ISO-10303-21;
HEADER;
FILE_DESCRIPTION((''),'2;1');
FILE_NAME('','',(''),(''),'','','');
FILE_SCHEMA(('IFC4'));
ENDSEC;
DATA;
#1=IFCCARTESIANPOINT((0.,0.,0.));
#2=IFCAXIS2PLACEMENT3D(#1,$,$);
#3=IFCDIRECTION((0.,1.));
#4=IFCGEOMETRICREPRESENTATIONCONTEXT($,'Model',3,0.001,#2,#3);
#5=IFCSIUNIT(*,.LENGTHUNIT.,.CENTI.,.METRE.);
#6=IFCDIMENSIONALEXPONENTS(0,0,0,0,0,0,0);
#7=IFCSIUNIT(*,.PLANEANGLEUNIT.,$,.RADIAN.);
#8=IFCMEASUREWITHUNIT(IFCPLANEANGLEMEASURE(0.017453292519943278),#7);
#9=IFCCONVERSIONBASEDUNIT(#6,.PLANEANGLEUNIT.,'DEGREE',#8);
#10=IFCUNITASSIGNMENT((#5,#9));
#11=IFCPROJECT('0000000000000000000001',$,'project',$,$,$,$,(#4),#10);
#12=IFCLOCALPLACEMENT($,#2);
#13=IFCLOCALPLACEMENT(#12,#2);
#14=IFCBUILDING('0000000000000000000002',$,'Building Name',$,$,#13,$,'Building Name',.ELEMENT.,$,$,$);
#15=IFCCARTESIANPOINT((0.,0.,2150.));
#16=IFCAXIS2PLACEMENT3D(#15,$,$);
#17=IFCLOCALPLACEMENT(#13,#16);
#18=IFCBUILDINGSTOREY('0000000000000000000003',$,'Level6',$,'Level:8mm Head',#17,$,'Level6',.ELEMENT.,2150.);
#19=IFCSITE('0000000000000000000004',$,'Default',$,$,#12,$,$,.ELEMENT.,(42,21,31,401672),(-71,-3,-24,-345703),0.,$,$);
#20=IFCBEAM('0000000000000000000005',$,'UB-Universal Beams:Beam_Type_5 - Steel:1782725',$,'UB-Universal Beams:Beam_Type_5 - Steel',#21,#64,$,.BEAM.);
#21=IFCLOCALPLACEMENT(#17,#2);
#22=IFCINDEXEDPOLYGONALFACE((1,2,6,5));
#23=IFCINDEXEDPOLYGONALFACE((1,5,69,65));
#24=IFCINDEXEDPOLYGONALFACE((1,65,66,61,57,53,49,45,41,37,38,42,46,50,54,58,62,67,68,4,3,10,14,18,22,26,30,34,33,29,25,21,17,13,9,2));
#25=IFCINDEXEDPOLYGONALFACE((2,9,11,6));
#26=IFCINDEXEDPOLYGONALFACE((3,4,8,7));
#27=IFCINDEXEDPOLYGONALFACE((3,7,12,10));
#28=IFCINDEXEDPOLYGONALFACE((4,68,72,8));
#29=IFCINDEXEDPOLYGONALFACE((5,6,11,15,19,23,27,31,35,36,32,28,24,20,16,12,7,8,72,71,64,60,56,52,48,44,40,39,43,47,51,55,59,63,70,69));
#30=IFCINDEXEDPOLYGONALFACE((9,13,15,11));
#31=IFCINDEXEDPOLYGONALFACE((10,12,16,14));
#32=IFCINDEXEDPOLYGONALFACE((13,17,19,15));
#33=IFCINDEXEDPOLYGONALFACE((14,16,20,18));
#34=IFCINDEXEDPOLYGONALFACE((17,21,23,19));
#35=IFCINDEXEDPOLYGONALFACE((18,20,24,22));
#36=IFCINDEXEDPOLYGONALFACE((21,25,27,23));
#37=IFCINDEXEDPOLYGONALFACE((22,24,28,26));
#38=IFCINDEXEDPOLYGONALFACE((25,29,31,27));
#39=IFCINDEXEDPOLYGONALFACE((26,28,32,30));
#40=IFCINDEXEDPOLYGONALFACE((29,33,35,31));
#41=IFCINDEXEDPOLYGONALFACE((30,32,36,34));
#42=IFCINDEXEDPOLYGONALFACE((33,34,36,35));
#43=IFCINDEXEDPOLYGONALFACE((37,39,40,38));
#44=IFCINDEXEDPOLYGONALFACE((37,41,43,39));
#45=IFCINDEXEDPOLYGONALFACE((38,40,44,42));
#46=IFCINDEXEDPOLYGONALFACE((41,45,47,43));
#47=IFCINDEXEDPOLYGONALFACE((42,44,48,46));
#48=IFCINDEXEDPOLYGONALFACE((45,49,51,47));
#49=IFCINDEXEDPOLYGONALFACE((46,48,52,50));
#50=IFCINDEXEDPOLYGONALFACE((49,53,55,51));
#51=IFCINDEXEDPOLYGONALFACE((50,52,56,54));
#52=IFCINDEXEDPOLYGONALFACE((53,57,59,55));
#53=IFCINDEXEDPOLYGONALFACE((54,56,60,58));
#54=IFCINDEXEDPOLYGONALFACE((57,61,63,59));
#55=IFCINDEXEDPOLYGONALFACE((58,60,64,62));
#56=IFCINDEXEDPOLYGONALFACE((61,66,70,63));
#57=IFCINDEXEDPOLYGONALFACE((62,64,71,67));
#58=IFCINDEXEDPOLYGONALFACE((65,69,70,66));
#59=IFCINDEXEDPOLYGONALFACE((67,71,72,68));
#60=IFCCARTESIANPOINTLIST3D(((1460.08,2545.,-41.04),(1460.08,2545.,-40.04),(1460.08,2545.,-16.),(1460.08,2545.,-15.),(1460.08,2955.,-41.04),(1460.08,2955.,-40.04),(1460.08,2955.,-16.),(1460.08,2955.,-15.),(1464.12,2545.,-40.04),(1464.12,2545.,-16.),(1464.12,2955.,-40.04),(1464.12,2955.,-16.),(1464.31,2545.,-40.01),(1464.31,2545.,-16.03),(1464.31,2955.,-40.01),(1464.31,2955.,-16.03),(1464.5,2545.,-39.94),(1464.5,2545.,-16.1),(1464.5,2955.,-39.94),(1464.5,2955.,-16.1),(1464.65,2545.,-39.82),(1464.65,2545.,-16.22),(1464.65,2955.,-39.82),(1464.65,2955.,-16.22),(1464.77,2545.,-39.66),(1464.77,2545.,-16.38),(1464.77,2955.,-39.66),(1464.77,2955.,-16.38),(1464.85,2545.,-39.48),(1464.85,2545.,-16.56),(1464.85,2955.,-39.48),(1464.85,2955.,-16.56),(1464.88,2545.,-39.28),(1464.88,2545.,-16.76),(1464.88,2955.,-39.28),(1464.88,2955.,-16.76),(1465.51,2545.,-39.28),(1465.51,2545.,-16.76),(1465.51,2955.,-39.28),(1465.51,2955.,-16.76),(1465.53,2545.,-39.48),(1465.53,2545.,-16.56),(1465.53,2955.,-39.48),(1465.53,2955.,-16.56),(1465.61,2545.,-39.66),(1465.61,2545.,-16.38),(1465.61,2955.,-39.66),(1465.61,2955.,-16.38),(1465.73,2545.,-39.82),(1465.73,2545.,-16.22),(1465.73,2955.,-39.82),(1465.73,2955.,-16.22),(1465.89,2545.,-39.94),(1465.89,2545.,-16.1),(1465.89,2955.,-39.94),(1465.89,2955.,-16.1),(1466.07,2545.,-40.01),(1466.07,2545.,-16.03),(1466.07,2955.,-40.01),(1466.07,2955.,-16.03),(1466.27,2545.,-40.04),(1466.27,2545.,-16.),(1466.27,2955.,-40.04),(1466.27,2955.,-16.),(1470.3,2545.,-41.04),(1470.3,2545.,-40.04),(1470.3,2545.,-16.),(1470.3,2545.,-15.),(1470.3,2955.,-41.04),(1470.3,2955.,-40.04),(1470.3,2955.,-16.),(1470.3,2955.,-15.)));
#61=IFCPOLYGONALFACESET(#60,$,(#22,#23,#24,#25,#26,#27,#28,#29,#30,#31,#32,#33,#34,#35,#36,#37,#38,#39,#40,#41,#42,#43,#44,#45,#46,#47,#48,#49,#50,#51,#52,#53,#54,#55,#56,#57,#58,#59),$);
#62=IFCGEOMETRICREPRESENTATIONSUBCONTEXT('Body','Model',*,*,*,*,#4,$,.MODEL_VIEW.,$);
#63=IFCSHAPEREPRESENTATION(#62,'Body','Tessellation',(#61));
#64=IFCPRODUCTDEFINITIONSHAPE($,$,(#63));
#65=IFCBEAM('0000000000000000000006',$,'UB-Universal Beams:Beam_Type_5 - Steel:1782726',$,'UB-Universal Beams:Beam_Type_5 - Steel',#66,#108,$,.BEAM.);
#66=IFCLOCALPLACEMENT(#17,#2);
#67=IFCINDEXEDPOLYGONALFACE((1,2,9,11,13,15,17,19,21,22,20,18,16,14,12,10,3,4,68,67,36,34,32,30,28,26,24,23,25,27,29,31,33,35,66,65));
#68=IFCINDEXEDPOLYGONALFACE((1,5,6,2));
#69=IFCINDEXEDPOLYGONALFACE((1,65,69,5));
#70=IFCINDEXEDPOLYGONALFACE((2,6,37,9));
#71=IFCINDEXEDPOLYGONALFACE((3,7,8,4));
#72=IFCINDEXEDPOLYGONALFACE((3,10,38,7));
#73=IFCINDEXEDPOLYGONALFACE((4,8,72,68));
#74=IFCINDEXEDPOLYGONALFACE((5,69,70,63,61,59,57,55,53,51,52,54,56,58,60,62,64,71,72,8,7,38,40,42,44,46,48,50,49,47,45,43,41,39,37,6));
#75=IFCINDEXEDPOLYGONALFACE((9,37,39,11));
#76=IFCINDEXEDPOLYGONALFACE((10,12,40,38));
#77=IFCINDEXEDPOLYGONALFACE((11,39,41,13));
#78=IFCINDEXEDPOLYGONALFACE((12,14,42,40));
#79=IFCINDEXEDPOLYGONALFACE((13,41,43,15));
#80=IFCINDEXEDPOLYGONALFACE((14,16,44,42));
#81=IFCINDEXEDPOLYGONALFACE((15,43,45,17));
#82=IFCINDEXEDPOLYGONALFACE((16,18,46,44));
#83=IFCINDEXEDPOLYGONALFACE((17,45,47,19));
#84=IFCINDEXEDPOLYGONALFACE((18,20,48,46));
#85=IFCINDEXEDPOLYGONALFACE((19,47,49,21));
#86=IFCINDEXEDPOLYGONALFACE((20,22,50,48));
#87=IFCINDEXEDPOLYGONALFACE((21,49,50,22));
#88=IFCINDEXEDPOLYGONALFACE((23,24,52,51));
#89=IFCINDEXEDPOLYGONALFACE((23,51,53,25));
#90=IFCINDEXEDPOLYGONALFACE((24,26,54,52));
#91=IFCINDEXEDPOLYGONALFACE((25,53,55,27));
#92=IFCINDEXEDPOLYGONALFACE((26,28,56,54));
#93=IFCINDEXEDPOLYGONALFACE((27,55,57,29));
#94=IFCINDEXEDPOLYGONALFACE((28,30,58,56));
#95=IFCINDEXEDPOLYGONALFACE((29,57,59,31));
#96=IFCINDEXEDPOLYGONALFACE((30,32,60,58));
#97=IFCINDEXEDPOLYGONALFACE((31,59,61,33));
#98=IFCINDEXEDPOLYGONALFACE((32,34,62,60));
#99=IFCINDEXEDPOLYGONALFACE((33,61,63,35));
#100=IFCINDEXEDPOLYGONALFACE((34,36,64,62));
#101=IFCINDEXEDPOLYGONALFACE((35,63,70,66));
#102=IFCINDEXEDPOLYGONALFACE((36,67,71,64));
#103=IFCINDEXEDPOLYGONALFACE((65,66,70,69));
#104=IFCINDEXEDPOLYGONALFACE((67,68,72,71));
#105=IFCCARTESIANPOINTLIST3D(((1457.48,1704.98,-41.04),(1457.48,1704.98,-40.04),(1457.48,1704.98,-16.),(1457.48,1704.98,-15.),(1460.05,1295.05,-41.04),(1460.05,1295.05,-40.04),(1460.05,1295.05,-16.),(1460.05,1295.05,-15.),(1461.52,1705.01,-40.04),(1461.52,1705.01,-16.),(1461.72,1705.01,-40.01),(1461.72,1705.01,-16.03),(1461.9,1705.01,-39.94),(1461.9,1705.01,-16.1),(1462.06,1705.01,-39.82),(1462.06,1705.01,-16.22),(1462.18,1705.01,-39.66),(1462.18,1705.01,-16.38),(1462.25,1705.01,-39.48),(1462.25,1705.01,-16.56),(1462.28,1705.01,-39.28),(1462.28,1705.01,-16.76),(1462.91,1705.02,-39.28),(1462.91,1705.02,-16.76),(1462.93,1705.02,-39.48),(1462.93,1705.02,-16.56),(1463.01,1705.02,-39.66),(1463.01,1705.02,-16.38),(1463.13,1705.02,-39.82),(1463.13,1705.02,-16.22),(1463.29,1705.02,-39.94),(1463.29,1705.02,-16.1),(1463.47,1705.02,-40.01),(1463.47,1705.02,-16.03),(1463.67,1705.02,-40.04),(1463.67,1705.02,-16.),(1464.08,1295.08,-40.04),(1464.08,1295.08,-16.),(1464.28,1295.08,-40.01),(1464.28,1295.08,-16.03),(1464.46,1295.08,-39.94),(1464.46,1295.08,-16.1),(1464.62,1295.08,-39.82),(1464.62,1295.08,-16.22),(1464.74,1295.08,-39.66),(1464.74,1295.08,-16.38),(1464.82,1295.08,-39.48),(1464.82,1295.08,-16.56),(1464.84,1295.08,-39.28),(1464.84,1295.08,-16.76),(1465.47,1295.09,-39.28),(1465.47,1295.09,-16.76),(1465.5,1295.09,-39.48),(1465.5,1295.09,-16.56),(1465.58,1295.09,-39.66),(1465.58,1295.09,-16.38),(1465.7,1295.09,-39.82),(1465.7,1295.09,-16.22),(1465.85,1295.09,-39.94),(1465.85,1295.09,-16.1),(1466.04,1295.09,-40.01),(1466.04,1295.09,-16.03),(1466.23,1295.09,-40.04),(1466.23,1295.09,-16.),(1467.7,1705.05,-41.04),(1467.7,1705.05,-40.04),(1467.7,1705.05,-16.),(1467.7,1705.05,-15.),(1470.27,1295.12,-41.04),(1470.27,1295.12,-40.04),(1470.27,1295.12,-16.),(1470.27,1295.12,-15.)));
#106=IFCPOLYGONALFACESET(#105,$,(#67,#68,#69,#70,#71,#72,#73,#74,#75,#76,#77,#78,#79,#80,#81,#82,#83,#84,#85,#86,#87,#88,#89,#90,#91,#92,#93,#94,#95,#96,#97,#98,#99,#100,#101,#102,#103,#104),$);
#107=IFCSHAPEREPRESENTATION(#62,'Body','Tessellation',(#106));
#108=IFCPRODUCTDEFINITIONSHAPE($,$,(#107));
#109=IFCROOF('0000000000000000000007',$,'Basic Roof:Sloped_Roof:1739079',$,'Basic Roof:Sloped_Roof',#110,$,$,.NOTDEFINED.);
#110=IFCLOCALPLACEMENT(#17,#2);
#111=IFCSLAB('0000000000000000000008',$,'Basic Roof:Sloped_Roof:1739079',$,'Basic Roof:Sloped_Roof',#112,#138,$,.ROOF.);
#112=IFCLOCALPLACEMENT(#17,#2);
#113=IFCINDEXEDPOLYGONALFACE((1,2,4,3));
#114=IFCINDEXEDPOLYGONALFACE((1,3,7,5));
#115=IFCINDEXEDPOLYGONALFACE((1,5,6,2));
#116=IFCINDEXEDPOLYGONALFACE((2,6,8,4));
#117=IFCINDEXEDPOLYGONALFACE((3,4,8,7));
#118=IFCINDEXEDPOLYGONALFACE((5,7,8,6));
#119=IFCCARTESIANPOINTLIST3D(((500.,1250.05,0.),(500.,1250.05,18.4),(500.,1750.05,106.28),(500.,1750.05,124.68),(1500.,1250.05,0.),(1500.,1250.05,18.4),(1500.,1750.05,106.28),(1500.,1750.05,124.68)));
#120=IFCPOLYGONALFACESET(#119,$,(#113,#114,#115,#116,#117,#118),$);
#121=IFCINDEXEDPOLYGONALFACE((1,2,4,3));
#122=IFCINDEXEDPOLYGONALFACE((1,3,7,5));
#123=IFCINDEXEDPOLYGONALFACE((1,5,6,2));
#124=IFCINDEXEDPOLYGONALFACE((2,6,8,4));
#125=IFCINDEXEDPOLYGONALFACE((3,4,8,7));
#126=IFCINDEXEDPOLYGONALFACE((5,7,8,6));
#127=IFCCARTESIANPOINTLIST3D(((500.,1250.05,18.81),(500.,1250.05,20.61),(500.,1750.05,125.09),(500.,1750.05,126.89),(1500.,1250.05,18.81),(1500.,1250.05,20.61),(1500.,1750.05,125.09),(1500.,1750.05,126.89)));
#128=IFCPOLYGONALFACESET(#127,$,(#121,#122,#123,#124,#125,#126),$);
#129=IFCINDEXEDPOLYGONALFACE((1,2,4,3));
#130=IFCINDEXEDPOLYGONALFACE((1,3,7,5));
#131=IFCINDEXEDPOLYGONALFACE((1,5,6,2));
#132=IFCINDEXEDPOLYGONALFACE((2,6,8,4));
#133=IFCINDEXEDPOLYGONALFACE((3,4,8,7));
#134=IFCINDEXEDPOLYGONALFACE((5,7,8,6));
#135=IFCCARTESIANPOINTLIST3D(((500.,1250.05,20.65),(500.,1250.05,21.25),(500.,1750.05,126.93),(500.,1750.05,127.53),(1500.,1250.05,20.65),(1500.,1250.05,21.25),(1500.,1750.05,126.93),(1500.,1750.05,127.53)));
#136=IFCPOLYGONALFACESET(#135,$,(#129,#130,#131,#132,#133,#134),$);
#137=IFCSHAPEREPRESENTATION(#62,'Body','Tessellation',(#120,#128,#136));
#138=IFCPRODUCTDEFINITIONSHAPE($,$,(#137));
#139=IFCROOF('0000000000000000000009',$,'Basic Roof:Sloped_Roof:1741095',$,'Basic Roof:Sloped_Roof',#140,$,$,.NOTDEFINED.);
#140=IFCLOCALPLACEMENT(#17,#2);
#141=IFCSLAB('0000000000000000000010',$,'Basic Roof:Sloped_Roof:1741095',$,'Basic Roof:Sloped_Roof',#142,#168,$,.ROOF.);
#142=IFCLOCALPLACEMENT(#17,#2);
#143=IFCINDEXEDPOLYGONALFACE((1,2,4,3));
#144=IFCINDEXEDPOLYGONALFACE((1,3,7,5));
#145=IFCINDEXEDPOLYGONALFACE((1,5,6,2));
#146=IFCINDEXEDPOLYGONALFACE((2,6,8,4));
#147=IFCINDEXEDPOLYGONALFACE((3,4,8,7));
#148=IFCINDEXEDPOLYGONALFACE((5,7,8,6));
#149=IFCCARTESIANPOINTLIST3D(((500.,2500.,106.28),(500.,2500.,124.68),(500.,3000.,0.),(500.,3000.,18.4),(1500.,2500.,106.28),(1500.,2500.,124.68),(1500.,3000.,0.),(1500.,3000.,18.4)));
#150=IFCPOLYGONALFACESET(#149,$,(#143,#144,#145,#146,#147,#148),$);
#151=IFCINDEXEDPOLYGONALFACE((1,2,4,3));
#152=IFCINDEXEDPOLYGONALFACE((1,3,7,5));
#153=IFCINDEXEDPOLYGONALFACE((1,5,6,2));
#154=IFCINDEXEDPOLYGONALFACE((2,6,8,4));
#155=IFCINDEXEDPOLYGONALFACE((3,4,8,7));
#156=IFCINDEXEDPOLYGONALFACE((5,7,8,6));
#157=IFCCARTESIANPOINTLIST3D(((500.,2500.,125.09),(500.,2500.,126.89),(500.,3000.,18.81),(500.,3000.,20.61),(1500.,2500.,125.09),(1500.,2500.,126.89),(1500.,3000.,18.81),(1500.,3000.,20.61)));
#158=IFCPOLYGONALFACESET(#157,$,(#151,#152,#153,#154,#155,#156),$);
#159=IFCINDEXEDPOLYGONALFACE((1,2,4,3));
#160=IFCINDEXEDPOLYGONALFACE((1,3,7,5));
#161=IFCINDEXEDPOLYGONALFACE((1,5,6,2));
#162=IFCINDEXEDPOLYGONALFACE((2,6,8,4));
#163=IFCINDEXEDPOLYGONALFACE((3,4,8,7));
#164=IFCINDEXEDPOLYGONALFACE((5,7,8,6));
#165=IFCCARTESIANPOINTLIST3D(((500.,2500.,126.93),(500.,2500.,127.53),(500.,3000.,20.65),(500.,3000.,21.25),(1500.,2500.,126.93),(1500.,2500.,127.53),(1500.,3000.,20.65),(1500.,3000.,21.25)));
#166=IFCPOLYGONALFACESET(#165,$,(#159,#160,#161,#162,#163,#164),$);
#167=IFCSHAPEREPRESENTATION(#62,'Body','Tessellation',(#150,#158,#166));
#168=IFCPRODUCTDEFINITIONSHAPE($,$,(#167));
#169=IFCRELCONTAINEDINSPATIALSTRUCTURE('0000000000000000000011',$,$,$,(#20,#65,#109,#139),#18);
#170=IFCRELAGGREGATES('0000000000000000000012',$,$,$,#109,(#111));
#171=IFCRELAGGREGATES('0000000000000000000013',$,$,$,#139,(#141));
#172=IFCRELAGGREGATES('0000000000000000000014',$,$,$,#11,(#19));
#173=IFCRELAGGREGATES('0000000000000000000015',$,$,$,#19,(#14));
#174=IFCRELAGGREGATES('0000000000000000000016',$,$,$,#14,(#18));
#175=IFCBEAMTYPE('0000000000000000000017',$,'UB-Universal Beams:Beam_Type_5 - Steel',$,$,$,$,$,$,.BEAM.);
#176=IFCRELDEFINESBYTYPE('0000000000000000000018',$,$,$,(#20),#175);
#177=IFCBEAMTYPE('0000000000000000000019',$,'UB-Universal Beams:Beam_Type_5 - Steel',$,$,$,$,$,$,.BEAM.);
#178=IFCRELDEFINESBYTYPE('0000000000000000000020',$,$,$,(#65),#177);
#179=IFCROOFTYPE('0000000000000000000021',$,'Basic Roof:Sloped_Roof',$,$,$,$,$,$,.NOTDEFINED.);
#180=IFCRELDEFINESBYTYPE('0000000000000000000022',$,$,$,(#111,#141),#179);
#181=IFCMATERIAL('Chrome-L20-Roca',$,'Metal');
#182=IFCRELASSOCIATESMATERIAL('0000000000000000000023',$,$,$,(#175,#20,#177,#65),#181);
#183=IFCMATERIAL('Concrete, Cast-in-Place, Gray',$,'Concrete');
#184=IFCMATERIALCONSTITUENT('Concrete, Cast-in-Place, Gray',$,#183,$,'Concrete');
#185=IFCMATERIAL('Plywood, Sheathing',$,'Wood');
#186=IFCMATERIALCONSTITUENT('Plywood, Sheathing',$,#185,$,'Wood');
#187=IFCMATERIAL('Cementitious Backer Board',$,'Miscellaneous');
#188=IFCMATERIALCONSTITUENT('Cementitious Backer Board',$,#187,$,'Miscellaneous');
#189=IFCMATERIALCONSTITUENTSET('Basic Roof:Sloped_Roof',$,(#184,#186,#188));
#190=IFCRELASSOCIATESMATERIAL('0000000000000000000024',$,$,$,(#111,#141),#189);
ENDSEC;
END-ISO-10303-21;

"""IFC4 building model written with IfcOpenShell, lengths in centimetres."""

from ifc_helpers import new_model, entity, si_unit, converted_unit, direction, frame, origin, place, context, subcontext, project, spatial, line, arc, indexed_curve, outline, extrude, source, transform, mapped, material, constituent, constituent_set, type_object, type_shapes, element, aggregate, save


model = new_model("IFC4")

# Units and contexts
model_context = context("Model", 3, precision=0.001, world=origin(), true_north=direction((0.0, 1.0)))
body_context = subcontext(model_context, "Body", "Model", "MODEL_VIEW")
ifc_project = project(units=[si_unit("LENGTHUNIT", "METRE", prefix="CENTI"), converted_unit("PLANEANGLEUNIT", "DEGREE", entity("IfcPlaneAngleMeasure", 0.017453292519943278), si_unit("PLANEANGLEUNIT", "RADIAN"), dimensions=[0, 0, 0, 0, 0, 0, 0])], contexts=[model_context])

# Site, building, storey
site_placement = place(None, origin())
site = spatial("IfcSite", under=ifc_project, at=site_placement, Name="Default", CompositionType="ELEMENT", RefLatitude=(42, 21, 31, 401672), RefLongitude=(-71, -3, -24, -345703), RefElevation=0.0)
building_placement = place(site_placement, origin())
building = spatial("IfcBuilding", under=site, at=building_placement, Name="Building Name", LongName="Building Name", CompositionType="ELEMENT")
storey_placement = place(building_placement, frame((0.0, 0.0, 2150.0)))
storey = spatial("IfcBuildingStorey", under=building, at=storey_placement, Name="Level6", ObjectType="Level:8mm Head", LongName="Level6", CompositionType="ELEMENT", Elevation=2150.0)

# Beams
ifc_material_1 = material(Name="Chrome-L20-Roca", Category="Metal")
beam_type_1 = type_object("IfcBeamType", Name="UB-Universal Beams:Beam_Type_5 - Steel", PredefinedType="BEAM", material=ifc_material_1)
shared_shape_1 = source(origin(), body_context, "Body", "SweptSolid", [
    extrude(outline(indexed_curve([(-5.11, -12.02), (-5.11, -13.02), (5.11, -13.02), (5.11, -12.02), (1.08, -12.02), (0.54, -11.8), (0.31, -11.26), (0.31, 11.26), (0.54, 11.8), (1.07, 12.02), (5.11, 12.02), (5.11, 13.02), (-5.11, 13.02), (-5.11, 12.02), (-1.08, 12.02), (-0.54, 11.8), (-0.32, 11.26), (-0.32, -11.26), (-0.54, -11.8), (-1.08, -12.02)], segments=[line(1, 2, 3, 4, 5), arc(5, 6, 7), line(7, 8), arc(8, 9, 10), line(10, 11, 12, 13, 14, 15), arc(15, 16, 17), line(17, 18), arc(18, 19, 20), line(20, 1)], self_intersect=False)), frame((-205.0, 0.0, 0.0), z_axis=(-1.0, 0.0, 0.0), x_axis=(0.0, -1.0, 0.0)), (0.0, 0.0, -1.0), 410.0),
])
type_shapes(beam_type_1, [shared_shape_1])
beam_1_placement = place(storey_placement, frame((1465.19, 2750.0, -28.02), z_axis=(0.0, 0.0, 1.0), x_axis=(0.0, -1.0, 0.0)))
element("IfcBeam", 1, at=beam_1_placement, inside=storey, type_object=beam_type_1, material=ifc_material_1, Name="UB-Universal Beams:Beam_Type_5 - Steel:1782725", ObjectType="UB-Universal Beams:Beam_Type_5 - Steel", PredefinedType="BEAM", context=body_context, shape_type="MappedRepresentation", body=[
    mapped(shared_shape_1, transform((0.0, 0.0, 0.0), scale=1.0)),
])
beam_type_2 = type_object("IfcBeamType", Name="UB-Universal Beams:Beam_Type_5 - Steel", PredefinedType="BEAM", material=ifc_material_1)
shared_shape_2 = source(origin(), body_context, "Body", "SweptSolid", [
    extrude(outline(indexed_curve([(-5.11, -12.02), (-5.11, -13.02), (5.11, -13.02), (5.11, -12.02), (1.08, -12.02), (0.54, -11.8), (0.31, -11.26), (0.31, 11.26), (0.54, 11.8), (1.07, 12.02), (5.11, 12.02), (5.11, 13.02), (-5.11, 13.02), (-5.11, 12.02), (-1.08, 12.02), (-0.54, 11.8), (-0.32, 11.26), (-0.32, -11.26), (-0.54, -11.8), (-1.08, -12.02)], segments=[line(1, 2, 3, 4, 5), arc(5, 6, 7), line(7, 8), arc(8, 9, 10), line(10, 11, 12, 13, 14, 15), arc(15, 16, 17), line(17, 18), arc(18, 19, 20), line(20, 1)], self_intersect=False)), frame((-199.97, 0.0, 0.0), z_axis=(-1.0, 0.0, 0.0), x_axis=(0.0, -1.0, 0.0)), (0.0, 0.0, -1.0), 409.94),
])
type_shapes(beam_type_2, [shared_shape_2])
beam_2_placement = place(storey_placement, frame((1463.85, 1505.05, -28.02), z_axis=(0.0, 0.0, 1.0), x_axis=(0.006256, -0.99998, 0.0)))
element("IfcBeam", 2, at=beam_2_placement, inside=storey, type_object=beam_type_2, material=ifc_material_1, Name="UB-Universal Beams:Beam_Type_5 - Steel:1782726", ObjectType="UB-Universal Beams:Beam_Type_5 - Steel", PredefinedType="BEAM", context=body_context, shape_type="MappedRepresentation", body=[
    mapped(shared_shape_2, transform((0.0, 0.0, 0.0), scale=1.0)),
])
ifc_material_2 = material(Name="Concrete, Cast-in-Place, Gray", Category="Concrete")

# Roofs, slabs
roof_1_placement = place(storey_placement, frame((500.0, 1250.05, 0.0)))
roof_1 = element("IfcRoof", 3, at=roof_1_placement, inside=storey, Name="Basic Roof:Sloped_Roof:1739079", ObjectType="Basic Roof:Sloped_Roof", PredefinedType="NOTDEFINED")
ifc_constituent_1 = constituent(ifc_material_2, Name="Concrete, Cast-in-Place, Gray", Category="Concrete")
ifc_material_3 = material(Name="Plywood, Sheathing", Category="Wood")
ifc_constituent_2 = constituent(ifc_material_3, Name="Plywood, Sheathing", Category="Wood")
ifc_material_4 = material(Name="Cementitious Backer Board", Category="Miscellaneous")
ifc_constituent_3 = constituent(ifc_material_4, Name="Cementitious Backer Board", Category="Miscellaneous")
ifc_constituent_set = constituent_set(constituents=[ifc_constituent_1, ifc_constituent_2, ifc_constituent_3], Name="Basic Roof:Sloped_Roof")
roof_type = type_object("IfcRoofType", Name="Basic Roof:Sloped_Roof", PredefinedType="NOTDEFINED")
slab_1_placement = place(roof_1_placement, origin())
slab_1 = element("IfcSlab", 4, at=slab_1_placement, type_object=roof_type, material=ifc_constituent_set, Name="Basic Roof:Sloped_Roof:1739079", ObjectType="Basic Roof:Sloped_Roof", PredefinedType="ROOF", context=body_context, shape_type="SweptSolid", body=[
    extrude(outline(indexed_curve([(500.0, 255.59), (-500.0, 255.59), (-500.0, -255.59), (500.0, -255.59), (500.0, 255.59)], self_intersect=False)), frame((500.0, 250.0, 53.14), z_axis=(0.0, -0.207912, 0.978148), x_axis=(1.0, 0.0, 0.0)), (0.0, 0.207912, 0.978148), 18.4),
    extrude(outline(indexed_curve([(500.0, 255.59), (-500.0, 255.59), (-500.0, -255.59), (500.0, -255.59), (500.0, 255.59)], self_intersect=False)), frame((500.0, 250.0, 71.95), z_axis=(0.0, -0.207912, 0.978148), x_axis=(1.0, 0.0, 0.0)), (0.0, 0.207912, 0.978148), 1.8),
    extrude(outline(indexed_curve([(500.0, 255.59), (-500.0, 255.59), (-500.0, -255.59), (500.0, -255.59), (500.0, 255.59)], self_intersect=False)), frame((500.0, 250.0, 73.79), z_axis=(0.0, -0.207912, 0.978148), x_axis=(1.0, 0.0, 0.0)), (0.0, 0.207912, 0.978148), 0.6),
])
aggregate(roof_1, [slab_1])
roof_2_placement = place(storey_placement, frame((500.0, 2500.0, 0.0)))
roof_2 = element("IfcRoof", 5, at=roof_2_placement, inside=storey, Name="Basic Roof:Sloped_Roof:1741095", ObjectType="Basic Roof:Sloped_Roof", PredefinedType="NOTDEFINED")
slab_2_placement = place(roof_2_placement, origin())
slab_2 = element("IfcSlab", 6, at=slab_2_placement, type_object=roof_type, material=ifc_constituent_set, Name="Basic Roof:Sloped_Roof:1741095", ObjectType="Basic Roof:Sloped_Roof", PredefinedType="ROOF", context=body_context, shape_type="SweptSolid", body=[
    extrude(outline(indexed_curve([(500.0, -255.59), (500.0, 255.59), (-500.0, 255.59), (-500.0, -255.59), (500.0, -255.59)], self_intersect=False)), frame((500.0, 250.0, 53.14), z_axis=(0.0, 0.207912, 0.978148), x_axis=(1.0, 0.0, 0.0)), (0.0, -0.207912, 0.978148), 18.4),
    extrude(outline(indexed_curve([(500.0, -255.59), (500.0, 255.59), (-500.0, 255.59), (-500.0, -255.59), (500.0, -255.59)], self_intersect=False)), frame((500.0, 250.0, 71.95), z_axis=(0.0, 0.207912, 0.978148), x_axis=(1.0, 0.0, 0.0)), (0.0, -0.207912, 0.978148), 1.8),
    extrude(outline(indexed_curve([(500.0, -255.59), (500.0, 255.59), (-500.0, 255.59), (-500.0, -255.59), (500.0, -255.59)], self_intersect=False)), frame((500.0, 250.0, 73.79), z_axis=(0.0, 0.207912, 0.978148), x_axis=(1.0, 0.0, 0.0)), (0.0, -0.207912, 0.978148), 0.6),
])
aggregate(roof_2, [slab_2])

save(model, "model.ifc")
